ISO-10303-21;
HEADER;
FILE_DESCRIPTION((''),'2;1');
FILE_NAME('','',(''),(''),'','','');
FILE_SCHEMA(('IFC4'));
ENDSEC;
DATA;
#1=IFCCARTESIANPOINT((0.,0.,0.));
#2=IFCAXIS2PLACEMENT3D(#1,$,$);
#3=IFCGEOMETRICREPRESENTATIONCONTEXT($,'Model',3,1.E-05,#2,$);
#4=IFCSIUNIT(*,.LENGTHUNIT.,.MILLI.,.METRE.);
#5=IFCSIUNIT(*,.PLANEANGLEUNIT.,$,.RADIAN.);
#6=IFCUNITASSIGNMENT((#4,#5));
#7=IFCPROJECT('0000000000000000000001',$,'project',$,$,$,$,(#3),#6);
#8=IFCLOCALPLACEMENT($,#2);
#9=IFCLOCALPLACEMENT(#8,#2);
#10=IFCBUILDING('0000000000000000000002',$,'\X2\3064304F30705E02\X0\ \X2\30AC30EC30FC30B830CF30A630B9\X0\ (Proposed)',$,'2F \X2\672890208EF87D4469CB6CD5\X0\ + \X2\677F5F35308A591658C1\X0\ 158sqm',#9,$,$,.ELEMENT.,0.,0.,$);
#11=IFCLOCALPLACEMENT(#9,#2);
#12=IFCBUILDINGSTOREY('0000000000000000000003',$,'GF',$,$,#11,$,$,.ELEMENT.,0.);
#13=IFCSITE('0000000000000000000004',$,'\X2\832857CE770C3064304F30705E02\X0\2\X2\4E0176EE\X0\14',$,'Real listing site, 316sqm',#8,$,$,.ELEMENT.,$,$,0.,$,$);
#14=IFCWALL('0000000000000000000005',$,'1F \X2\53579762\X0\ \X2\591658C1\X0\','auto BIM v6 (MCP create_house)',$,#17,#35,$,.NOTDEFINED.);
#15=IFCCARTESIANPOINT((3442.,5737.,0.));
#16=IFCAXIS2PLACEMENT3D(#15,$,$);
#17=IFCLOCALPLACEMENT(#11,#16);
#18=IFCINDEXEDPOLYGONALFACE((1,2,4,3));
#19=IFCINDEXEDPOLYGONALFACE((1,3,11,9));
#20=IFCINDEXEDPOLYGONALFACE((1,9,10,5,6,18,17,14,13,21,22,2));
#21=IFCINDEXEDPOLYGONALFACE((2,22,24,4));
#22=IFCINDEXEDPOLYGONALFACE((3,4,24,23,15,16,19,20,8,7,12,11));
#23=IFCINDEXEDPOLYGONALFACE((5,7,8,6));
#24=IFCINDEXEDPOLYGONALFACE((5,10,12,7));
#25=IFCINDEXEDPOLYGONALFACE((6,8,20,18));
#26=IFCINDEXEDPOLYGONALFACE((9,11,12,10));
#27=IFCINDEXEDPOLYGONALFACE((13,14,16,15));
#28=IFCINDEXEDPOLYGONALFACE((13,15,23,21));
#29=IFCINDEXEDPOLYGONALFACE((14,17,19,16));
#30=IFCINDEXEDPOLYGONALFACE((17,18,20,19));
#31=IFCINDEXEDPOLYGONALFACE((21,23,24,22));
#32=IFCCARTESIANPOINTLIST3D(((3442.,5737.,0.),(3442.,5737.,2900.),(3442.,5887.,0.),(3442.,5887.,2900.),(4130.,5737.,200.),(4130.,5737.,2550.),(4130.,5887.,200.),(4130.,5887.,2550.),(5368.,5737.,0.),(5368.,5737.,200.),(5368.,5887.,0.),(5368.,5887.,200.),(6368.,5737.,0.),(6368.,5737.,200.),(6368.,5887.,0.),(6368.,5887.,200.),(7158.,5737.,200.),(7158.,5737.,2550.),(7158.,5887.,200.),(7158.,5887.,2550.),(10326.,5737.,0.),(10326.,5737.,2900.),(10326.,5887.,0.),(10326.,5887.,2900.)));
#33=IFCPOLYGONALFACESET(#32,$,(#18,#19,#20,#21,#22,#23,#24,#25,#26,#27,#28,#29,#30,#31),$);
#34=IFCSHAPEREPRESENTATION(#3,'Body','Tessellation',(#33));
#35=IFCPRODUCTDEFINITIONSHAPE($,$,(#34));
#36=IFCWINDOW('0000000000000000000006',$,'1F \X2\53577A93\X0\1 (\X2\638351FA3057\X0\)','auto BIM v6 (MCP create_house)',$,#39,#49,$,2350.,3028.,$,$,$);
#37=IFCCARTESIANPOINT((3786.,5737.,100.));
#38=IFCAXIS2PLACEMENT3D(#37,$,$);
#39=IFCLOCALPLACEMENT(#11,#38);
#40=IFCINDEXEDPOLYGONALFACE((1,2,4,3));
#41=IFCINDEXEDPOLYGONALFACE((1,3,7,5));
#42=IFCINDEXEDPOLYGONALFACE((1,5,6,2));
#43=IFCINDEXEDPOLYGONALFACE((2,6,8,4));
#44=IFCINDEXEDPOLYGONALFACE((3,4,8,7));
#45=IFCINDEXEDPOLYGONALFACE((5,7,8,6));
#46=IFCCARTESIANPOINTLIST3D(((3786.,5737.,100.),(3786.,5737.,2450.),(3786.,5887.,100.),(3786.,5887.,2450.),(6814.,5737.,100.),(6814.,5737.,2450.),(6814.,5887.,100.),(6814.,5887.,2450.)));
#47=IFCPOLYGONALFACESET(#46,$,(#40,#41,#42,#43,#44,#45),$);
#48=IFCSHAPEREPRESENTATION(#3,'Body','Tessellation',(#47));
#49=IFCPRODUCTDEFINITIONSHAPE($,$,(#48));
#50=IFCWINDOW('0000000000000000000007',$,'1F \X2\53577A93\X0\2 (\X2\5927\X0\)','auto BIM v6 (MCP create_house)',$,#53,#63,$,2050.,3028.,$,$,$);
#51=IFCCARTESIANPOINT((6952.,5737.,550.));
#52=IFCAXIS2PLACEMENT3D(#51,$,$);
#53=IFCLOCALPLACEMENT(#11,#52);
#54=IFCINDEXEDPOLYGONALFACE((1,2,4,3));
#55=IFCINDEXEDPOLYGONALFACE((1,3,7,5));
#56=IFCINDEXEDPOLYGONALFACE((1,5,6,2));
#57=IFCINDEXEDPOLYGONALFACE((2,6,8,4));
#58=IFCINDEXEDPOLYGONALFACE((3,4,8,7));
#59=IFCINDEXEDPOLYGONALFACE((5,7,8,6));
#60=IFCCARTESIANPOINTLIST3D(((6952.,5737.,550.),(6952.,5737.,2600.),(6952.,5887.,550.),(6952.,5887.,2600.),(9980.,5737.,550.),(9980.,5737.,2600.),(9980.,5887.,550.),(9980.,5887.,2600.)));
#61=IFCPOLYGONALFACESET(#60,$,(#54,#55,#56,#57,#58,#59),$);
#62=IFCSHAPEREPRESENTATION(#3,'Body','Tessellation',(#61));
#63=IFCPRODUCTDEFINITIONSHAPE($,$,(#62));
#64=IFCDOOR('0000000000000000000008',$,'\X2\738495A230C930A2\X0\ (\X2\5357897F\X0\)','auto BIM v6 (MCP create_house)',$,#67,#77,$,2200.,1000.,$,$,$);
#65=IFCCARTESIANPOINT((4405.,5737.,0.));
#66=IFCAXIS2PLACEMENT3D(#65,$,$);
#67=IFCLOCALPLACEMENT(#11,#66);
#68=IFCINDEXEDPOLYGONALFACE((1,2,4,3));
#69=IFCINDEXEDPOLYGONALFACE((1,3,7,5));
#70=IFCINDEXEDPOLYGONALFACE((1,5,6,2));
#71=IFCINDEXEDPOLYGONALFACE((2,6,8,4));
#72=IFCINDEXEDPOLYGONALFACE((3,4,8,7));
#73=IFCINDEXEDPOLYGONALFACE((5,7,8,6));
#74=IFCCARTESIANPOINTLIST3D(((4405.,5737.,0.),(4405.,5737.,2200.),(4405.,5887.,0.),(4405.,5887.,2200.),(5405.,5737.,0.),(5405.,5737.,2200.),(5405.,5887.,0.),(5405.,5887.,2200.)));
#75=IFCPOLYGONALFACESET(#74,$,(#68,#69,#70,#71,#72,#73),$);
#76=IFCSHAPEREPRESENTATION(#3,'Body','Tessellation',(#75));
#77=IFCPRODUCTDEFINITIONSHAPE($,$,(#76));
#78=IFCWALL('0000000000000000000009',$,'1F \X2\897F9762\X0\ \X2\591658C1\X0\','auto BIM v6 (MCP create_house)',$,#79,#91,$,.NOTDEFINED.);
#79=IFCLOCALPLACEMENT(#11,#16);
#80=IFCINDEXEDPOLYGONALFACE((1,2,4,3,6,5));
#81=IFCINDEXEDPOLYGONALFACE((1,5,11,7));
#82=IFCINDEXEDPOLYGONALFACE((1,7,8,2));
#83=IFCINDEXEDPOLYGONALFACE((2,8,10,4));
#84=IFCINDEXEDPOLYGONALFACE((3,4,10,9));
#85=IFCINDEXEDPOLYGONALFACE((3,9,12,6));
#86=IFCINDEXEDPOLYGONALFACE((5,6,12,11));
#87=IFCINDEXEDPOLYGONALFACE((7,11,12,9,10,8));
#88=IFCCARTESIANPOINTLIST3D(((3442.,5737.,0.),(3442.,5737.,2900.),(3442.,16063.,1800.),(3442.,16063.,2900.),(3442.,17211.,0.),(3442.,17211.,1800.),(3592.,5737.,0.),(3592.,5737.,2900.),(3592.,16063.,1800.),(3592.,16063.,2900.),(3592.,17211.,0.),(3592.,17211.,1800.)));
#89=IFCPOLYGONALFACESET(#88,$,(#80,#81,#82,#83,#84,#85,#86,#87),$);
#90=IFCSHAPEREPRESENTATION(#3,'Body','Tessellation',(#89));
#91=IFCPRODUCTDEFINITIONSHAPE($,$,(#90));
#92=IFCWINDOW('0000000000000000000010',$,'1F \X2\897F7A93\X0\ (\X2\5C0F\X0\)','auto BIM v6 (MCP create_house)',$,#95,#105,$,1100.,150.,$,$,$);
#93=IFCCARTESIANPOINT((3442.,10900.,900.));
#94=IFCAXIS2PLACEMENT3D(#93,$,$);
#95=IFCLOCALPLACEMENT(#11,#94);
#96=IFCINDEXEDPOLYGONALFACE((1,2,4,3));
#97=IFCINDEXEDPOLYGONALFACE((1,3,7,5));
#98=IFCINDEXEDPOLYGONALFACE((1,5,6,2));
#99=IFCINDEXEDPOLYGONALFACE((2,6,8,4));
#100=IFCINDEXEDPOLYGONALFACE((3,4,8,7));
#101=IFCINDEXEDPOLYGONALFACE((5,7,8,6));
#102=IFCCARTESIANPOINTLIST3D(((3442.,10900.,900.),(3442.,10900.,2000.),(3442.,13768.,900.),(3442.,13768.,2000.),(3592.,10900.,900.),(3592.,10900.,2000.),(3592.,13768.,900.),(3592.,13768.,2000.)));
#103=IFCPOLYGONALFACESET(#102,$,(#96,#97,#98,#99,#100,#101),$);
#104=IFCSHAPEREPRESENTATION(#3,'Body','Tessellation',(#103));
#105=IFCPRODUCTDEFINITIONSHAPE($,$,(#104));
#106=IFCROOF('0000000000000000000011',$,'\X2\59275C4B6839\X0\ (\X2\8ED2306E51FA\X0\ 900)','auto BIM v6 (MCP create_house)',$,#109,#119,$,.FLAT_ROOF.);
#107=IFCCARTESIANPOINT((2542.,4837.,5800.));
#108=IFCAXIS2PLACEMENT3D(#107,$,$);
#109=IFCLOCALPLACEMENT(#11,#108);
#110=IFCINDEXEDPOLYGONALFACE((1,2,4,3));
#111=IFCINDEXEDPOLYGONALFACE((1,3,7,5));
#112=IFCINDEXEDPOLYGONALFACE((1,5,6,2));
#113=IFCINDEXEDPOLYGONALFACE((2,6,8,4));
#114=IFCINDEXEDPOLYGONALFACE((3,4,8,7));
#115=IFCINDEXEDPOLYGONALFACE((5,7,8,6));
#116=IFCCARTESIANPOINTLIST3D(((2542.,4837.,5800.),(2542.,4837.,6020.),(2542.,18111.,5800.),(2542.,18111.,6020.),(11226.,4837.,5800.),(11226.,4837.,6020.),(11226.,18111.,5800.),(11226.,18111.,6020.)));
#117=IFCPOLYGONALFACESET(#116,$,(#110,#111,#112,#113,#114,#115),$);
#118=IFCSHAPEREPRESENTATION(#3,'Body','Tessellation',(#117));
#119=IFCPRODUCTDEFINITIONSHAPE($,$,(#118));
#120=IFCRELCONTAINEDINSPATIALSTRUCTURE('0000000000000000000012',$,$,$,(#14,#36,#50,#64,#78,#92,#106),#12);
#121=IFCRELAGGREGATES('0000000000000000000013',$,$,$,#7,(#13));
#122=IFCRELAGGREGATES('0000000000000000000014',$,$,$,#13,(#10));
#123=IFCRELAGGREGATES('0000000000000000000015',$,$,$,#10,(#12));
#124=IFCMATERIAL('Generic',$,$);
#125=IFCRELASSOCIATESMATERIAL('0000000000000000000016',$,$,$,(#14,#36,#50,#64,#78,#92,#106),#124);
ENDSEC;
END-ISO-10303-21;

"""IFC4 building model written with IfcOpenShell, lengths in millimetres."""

from ifc_helpers import new_model, si_unit, frame, frame_2d, origin, place, context, project, spatial, rectangle, extrude, material, element, fill, save


model = new_model("IFC4")

# Units and contexts
model_context = context("Model", 3, precision=1e-05, world=origin())
ifc_project = project(units=[si_unit("LENGTHUNIT", "METRE", prefix="MILLI"), si_unit("PLANEANGLEUNIT", "RADIAN")], contexts=[model_context])

# Site, building, storey
site_placement = place(None, origin())
site = spatial("IfcSite", under=ifc_project, at=site_placement, Name="茨城県つくば市2丁目14", ObjectType="Real listing site, 316sqm", CompositionType="ELEMENT", RefElevation=0.0)
building_placement = place(site_placement, origin())
building = spatial("IfcBuilding", under=site, at=building_placement, Name="つくば市 ガレージハウス (Proposed)", ObjectType="2F 木造軸組構法 + 板張り外壁 158sqm", CompositionType="ELEMENT", ElevationOfRefHeight=0.0, ElevationOfTerrain=0.0)
storey_placement = place(building_placement, origin())
storey = spatial("IfcBuildingStorey", under=building, at=storey_placement, Name="GF", CompositionType="ELEMENT", Elevation=0.0)

# Shared definitions
ifc_material = material(Name="Generic")

# Wall, openings, windows, door
wall_1_placement = place(storey_placement, frame((3442.0, 5737.0, 0.0)))
wall_1 = element("IfcWall", 1, at=wall_1_placement, inside=storey, material=ifc_material, Name="1F 南面 外壁", Description="auto BIM v6 (MCP create_house)", PredefinedType="NOTDEFINED", context=model_context, shape_type="SweptSolid", body=[
    extrude(rectangle(XDim=6884.0, YDim=150.0, at=frame_2d((3442.0, 75.0))), frame((3442.0, 5737.0, 0.0)), (0.0, 0.0, 1.0), 2900.0),
])
opening_1_placement = place(storey_placement, frame((3786.0, 5737.0, 100.0)))
opening_1 = element("IfcOpeningElement", 2, at=opening_1_placement, cuts=wall_1, PredefinedType="NOTDEFINED", context=model_context, shape_type="SweptSolid", body=[
    extrude(rectangle(XDim=3028.0, YDim=150.0, at=frame_2d((1514.0, 75.0))), frame((3786.0, 5737.0, 100.0)), (0.0, 0.0, 1.0), 2350.0),
])
opening_2_placement = place(storey_placement, frame((6952.0, 5737.0, 550.0)))
opening_2 = element("IfcOpeningElement", 3, at=opening_2_placement, cuts=wall_1, PredefinedType="NOTDEFINED", context=model_context, shape_type="SweptSolid", body=[
    extrude(rectangle(XDim=3028.0, YDim=150.0, at=frame_2d((1514.0, 75.0))), frame((6952.0, 5737.0, 550.0)), (0.0, 0.0, 1.0), 2050.0),
])
opening_3_placement = place(storey_placement, frame((4405.0, 5737.0, 0.0)))
opening_3 = element("IfcOpeningElement", 4, at=opening_3_placement, cuts=wall_1, PredefinedType="NOTDEFINED", context=model_context, shape_type="SweptSolid", body=[
    extrude(rectangle(XDim=1000.0, YDim=150.0, at=frame_2d((500.0, 75.0))), frame((4405.0, 5737.0, 0.0)), (0.0, 0.0, 1.0), 2200.0),
])
window_1_placement = place(storey_placement, frame((3786.0, 5737.0, 100.0)))
window_1 = element("IfcWindow", 5, at=window_1_placement, inside=storey, material=ifc_material, Name="1F 南窓1 (掃出し)", Description="auto BIM v6 (MCP create_house)", OverallHeight=2350.0, OverallWidth=3028.0, context=model_context, shape_type="SweptSolid", body=[
    extrude(rectangle(XDim=3028.0, YDim=150.0, at=frame_2d((1514.0, 75.0))), frame((3786.0, 5737.0, 100.0)), (0.0, 0.0, 1.0), 2350.0),
])
fill(opening_1, window_1)
window_2_placement = place(storey_placement, frame((6952.0, 5737.0, 550.0)))
window_2 = element("IfcWindow", 6, at=window_2_placement, inside=storey, material=ifc_material, Name="1F 南窓2 (大)", Description="auto BIM v6 (MCP create_house)", OverallHeight=2050.0, OverallWidth=3028.0, context=model_context, shape_type="SweptSolid", body=[
    extrude(rectangle(XDim=3028.0, YDim=150.0, at=frame_2d((1514.0, 75.0))), frame((6952.0, 5737.0, 550.0)), (0.0, 0.0, 1.0), 2050.0),
])
fill(opening_2, window_2)
door_placement = place(storey_placement, frame((4405.0, 5737.0, 0.0)))
door = element("IfcDoor", 7, at=door_placement, inside=storey, material=ifc_material, Name="玄関ドア (南西)", Description="auto BIM v6 (MCP create_house)", OverallHeight=2200.0, OverallWidth=1000.0, context=model_context, shape_type="SweptSolid", body=[
    extrude(rectangle(XDim=1000.0, YDim=150.0, at=frame_2d((500.0, 75.0))), frame((4405.0, 5737.0, 0.0)), (0.0, 0.0, 1.0), 2200.0),
])
fill(opening_3, door)

# Wall, opening, window
wall_2_placement = place(storey_placement, frame((3442.0, 5737.0, 0.0)))
wall_2 = element("IfcWall", 8, at=wall_2_placement, inside=storey, material=ifc_material, Name="1F 西面 外壁", Description="auto BIM v6 (MCP create_house)", PredefinedType="NOTDEFINED", context=model_context, shape_type="SweptSolid", body=[
    extrude(rectangle(XDim=150.0, YDim=11474.0, at=frame_2d((75.0, 5737.0))), frame((3442.0, 5737.0, 0.0)), (0.0, 0.0, 1.0), 2900.0),
])
opening_4_placement = place(storey_placement, frame((3442.0, 10900.0, 900.0)))
opening_4 = element("IfcOpeningElement", 9, at=opening_4_placement, cuts=wall_2, PredefinedType="NOTDEFINED", context=model_context, shape_type="SweptSolid", body=[
    extrude(rectangle(XDim=150.0, YDim=2868.0, at=frame_2d((75.0, 1434.0))), frame((3442.0, 10900.0, 900.0)), (0.0, 0.0, 1.0), 1100.0),
])
window_3_placement = place(storey_placement, frame((3442.0, 10900.0, 900.0)))
window_3 = element("IfcWindow", 10, at=window_3_placement, inside=storey, material=ifc_material, Name="1F 西窓 (小)", Description="auto BIM v6 (MCP create_house)", OverallHeight=1100.0, OverallWidth=150.0, context=model_context, shape_type="SweptSolid", body=[
    extrude(rectangle(XDim=150.0, YDim=2868.0, at=frame_2d((75.0, 1434.0))), frame((3442.0, 10900.0, 900.0)), (0.0, 0.0, 1.0), 1100.0),
])
fill(opening_4, window_3)

# Roof
roof_placement = place(storey_placement, frame((2542.0, 4837.0, 5800.0)))
element("IfcRoof", 11, at=roof_placement, inside=storey, material=ifc_material, Name="大屋根 (軒の出 900)", Description="auto BIM v6 (MCP create_house)", PredefinedType="FLAT_ROOF", context=model_context, shape_type="SweptSolid", body=[
    extrude(rectangle(XDim=8684.0, YDim=13274.0, at=frame_2d((4342.0, 6637.0))), frame((2542.0, 4837.0, 5800.0)), (0.0, 0.0, 1.0), 220.0),
])

save(model, "model.ifc")
